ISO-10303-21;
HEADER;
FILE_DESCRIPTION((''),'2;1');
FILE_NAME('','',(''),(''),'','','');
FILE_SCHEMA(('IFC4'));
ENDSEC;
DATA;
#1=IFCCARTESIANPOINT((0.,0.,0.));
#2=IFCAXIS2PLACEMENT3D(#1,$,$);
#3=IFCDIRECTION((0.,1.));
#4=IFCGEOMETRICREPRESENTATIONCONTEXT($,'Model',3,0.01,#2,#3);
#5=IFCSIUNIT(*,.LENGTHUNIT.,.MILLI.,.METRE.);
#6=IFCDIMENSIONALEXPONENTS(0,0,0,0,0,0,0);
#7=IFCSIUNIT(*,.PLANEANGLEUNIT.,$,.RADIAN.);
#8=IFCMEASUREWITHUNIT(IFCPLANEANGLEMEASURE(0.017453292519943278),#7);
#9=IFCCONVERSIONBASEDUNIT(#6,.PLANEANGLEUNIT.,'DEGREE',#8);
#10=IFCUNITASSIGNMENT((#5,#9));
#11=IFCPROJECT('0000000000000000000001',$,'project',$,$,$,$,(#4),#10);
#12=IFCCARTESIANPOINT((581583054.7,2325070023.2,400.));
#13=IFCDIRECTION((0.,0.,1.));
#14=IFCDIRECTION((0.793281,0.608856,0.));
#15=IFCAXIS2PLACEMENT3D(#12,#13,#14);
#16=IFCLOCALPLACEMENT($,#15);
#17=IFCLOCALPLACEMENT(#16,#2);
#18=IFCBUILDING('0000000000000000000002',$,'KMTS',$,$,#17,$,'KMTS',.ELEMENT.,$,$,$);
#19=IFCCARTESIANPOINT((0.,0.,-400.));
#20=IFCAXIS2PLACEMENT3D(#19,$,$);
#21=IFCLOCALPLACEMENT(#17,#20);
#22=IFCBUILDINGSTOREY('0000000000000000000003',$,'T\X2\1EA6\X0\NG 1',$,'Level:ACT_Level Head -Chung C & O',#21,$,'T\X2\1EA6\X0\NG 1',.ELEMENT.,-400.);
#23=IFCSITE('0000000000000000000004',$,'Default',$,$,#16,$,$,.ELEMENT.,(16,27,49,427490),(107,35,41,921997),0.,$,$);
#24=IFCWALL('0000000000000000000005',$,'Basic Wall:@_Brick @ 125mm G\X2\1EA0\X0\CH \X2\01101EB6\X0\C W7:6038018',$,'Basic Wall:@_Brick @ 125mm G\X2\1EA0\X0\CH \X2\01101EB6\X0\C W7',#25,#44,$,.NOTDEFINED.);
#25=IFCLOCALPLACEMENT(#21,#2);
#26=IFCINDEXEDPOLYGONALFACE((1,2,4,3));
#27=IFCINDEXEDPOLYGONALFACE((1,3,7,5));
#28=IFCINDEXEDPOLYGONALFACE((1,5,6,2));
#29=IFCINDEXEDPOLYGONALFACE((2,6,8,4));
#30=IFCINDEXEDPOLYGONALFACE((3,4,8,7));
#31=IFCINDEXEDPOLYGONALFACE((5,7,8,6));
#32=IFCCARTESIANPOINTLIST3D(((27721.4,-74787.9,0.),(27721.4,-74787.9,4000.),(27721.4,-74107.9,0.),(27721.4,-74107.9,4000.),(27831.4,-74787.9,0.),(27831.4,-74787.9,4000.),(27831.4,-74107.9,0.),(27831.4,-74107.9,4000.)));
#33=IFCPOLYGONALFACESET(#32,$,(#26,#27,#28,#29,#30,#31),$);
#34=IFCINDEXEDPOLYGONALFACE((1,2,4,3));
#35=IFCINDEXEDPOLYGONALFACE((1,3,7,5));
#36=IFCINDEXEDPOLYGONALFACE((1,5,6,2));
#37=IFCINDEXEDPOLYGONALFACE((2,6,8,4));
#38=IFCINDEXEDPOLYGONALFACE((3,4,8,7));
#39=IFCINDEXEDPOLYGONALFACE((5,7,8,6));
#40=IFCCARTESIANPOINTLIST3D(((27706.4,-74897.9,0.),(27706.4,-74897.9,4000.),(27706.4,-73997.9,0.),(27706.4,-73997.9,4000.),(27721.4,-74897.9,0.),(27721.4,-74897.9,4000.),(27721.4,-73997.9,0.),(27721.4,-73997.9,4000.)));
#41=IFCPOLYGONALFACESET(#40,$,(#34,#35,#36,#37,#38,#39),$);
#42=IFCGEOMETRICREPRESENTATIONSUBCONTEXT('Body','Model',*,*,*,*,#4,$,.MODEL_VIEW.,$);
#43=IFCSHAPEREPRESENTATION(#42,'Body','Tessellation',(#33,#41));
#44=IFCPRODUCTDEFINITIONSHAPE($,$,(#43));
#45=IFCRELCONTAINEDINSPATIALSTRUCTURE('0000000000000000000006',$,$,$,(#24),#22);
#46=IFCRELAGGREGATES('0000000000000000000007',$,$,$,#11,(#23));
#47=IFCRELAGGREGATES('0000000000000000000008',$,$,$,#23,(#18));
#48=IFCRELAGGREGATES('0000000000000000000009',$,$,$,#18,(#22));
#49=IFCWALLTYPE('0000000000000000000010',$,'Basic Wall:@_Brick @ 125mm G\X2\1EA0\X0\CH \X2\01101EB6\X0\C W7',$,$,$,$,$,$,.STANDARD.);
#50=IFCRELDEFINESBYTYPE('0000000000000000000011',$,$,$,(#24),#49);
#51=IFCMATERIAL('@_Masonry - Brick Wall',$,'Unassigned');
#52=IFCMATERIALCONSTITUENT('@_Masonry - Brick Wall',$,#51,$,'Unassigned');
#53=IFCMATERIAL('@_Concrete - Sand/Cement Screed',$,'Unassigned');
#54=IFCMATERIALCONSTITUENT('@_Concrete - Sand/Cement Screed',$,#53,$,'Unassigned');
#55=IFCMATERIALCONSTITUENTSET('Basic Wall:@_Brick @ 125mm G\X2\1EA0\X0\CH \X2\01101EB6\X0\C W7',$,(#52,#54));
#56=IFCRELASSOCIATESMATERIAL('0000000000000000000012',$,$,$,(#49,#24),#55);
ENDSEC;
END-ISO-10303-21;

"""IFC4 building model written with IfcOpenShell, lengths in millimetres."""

from ifc_helpers import new_model, entity, si_unit, converted_unit, direction, frame, origin, place, context, subcontext, project, spatial, indexed_curve, outline, extrude, material, constituent, constituent_set, type_object, element, save


model = new_model("IFC4")

# Units and contexts
model_context = context("Model", 3, precision=0.01, world=origin(), true_north=direction((0.0, 1.0)))
body_context = subcontext(model_context, "Body", "Model", "MODEL_VIEW")
ifc_project = project(units=[si_unit("LENGTHUNIT", "METRE", prefix="MILLI"), converted_unit("PLANEANGLEUNIT", "DEGREE", entity("IfcPlaneAngleMeasure", 0.017453292519943278), si_unit("PLANEANGLEUNIT", "RADIAN"), dimensions=[0, 0, 0, 0, 0, 0, 0])], contexts=[model_context])

# Site, building, storey
site_placement = place(None, frame((581583054.7, 2325070023.2, 400.0), z_axis=(0.0, 0.0, 1.0), x_axis=(0.793281, 0.608856, 0.0)))
site = spatial("IfcSite", under=ifc_project, at=site_placement, Name="Default", CompositionType="ELEMENT", RefLatitude=(16, 27, 49, 427490), RefLongitude=(107, 35, 41, 921997), RefElevation=0.0)
building_placement = place(site_placement, origin())
building = spatial("IfcBuilding", under=site, at=building_placement, Name="KMTS", LongName="KMTS", CompositionType="ELEMENT")
storey_placement = place(building_placement, frame((0.0, 0.0, -400.0)))
storey = spatial("IfcBuildingStorey", under=building, at=storey_placement, Name="TẦNG 1", ObjectType="Level:ACT_Level Head -Chung C & O", LongName="TẦNG 1", CompositionType="ELEMENT", Elevation=-400.0)

# Wall
ifc_material_1 = material(Name="@_Masonry - Brick Wall", Category="Unassigned")
ifc_constituent_1 = constituent(ifc_material_1, Name="@_Masonry - Brick Wall", Category="Unassigned")
ifc_material_2 = material(Name="@_Concrete - Sand/Cement Screed", Category="Unassigned")
ifc_constituent_2 = constituent(ifc_material_2, Name="@_Concrete - Sand/Cement Screed", Category="Unassigned")
ifc_constituent_set_1 = constituent_set(constituents=[ifc_constituent_1, ifc_constituent_2], Name="Basic Wall:@_Brick @ 125mm GẠCH ĐẶC W7")
wall_type_1 = type_object("IfcWallType", Name="Basic Wall:@_Brick @ 125mm GẠCH ĐẶC W7", PredefinedType="STANDARD", material=ifc_constituent_set_1)
wall_1_placement = place(storey_placement, frame((27768.9, -74107.9, 0.0), z_axis=(0.0, 0.0, 1.0), x_axis=(0.0, -1.0, 0.0)))
element("IfcWall", 1, at=wall_1_placement, inside=storey, type_object=wall_type_1, material=ifc_constituent_set_1, Name="Basic Wall:@_Brick @ 125mm GẠCH ĐẶC W7:6038018", ObjectType="Basic Wall:@_Brick @ 125mm GẠCH ĐẶC W7", PredefinedType="NOTDEFINED", context=body_context, shape_type="SweptSolid", body=[
    extrude(outline(indexed_curve([(-55.0, -340.0), (55.0, -340.0), (55.0, 340.0), (-55.0, 340.0), (-55.0, -340.0)], self_intersect=False)), frame((340.0, 7.5, 0.0), z_axis=(0.0, 0.0, 1.0), x_axis=(0.0, -1.0, 0.0)), (0.0, 0.0, 1.0), 4000.0),
    extrude(outline(indexed_curve([(-7.5, -450.0), (7.5, -450.0), (7.5, 450.0), (-7.5, 450.0), (-7.5, -450.0)], self_intersect=False)), frame((340.0, -55.0, 0.0), z_axis=(0.0, 0.0, 1.0), x_axis=(0.0, 1.0, 0.0)), (0.0, 0.0, 1.0), 4000.0),
])

save(model, "model.ifc")
